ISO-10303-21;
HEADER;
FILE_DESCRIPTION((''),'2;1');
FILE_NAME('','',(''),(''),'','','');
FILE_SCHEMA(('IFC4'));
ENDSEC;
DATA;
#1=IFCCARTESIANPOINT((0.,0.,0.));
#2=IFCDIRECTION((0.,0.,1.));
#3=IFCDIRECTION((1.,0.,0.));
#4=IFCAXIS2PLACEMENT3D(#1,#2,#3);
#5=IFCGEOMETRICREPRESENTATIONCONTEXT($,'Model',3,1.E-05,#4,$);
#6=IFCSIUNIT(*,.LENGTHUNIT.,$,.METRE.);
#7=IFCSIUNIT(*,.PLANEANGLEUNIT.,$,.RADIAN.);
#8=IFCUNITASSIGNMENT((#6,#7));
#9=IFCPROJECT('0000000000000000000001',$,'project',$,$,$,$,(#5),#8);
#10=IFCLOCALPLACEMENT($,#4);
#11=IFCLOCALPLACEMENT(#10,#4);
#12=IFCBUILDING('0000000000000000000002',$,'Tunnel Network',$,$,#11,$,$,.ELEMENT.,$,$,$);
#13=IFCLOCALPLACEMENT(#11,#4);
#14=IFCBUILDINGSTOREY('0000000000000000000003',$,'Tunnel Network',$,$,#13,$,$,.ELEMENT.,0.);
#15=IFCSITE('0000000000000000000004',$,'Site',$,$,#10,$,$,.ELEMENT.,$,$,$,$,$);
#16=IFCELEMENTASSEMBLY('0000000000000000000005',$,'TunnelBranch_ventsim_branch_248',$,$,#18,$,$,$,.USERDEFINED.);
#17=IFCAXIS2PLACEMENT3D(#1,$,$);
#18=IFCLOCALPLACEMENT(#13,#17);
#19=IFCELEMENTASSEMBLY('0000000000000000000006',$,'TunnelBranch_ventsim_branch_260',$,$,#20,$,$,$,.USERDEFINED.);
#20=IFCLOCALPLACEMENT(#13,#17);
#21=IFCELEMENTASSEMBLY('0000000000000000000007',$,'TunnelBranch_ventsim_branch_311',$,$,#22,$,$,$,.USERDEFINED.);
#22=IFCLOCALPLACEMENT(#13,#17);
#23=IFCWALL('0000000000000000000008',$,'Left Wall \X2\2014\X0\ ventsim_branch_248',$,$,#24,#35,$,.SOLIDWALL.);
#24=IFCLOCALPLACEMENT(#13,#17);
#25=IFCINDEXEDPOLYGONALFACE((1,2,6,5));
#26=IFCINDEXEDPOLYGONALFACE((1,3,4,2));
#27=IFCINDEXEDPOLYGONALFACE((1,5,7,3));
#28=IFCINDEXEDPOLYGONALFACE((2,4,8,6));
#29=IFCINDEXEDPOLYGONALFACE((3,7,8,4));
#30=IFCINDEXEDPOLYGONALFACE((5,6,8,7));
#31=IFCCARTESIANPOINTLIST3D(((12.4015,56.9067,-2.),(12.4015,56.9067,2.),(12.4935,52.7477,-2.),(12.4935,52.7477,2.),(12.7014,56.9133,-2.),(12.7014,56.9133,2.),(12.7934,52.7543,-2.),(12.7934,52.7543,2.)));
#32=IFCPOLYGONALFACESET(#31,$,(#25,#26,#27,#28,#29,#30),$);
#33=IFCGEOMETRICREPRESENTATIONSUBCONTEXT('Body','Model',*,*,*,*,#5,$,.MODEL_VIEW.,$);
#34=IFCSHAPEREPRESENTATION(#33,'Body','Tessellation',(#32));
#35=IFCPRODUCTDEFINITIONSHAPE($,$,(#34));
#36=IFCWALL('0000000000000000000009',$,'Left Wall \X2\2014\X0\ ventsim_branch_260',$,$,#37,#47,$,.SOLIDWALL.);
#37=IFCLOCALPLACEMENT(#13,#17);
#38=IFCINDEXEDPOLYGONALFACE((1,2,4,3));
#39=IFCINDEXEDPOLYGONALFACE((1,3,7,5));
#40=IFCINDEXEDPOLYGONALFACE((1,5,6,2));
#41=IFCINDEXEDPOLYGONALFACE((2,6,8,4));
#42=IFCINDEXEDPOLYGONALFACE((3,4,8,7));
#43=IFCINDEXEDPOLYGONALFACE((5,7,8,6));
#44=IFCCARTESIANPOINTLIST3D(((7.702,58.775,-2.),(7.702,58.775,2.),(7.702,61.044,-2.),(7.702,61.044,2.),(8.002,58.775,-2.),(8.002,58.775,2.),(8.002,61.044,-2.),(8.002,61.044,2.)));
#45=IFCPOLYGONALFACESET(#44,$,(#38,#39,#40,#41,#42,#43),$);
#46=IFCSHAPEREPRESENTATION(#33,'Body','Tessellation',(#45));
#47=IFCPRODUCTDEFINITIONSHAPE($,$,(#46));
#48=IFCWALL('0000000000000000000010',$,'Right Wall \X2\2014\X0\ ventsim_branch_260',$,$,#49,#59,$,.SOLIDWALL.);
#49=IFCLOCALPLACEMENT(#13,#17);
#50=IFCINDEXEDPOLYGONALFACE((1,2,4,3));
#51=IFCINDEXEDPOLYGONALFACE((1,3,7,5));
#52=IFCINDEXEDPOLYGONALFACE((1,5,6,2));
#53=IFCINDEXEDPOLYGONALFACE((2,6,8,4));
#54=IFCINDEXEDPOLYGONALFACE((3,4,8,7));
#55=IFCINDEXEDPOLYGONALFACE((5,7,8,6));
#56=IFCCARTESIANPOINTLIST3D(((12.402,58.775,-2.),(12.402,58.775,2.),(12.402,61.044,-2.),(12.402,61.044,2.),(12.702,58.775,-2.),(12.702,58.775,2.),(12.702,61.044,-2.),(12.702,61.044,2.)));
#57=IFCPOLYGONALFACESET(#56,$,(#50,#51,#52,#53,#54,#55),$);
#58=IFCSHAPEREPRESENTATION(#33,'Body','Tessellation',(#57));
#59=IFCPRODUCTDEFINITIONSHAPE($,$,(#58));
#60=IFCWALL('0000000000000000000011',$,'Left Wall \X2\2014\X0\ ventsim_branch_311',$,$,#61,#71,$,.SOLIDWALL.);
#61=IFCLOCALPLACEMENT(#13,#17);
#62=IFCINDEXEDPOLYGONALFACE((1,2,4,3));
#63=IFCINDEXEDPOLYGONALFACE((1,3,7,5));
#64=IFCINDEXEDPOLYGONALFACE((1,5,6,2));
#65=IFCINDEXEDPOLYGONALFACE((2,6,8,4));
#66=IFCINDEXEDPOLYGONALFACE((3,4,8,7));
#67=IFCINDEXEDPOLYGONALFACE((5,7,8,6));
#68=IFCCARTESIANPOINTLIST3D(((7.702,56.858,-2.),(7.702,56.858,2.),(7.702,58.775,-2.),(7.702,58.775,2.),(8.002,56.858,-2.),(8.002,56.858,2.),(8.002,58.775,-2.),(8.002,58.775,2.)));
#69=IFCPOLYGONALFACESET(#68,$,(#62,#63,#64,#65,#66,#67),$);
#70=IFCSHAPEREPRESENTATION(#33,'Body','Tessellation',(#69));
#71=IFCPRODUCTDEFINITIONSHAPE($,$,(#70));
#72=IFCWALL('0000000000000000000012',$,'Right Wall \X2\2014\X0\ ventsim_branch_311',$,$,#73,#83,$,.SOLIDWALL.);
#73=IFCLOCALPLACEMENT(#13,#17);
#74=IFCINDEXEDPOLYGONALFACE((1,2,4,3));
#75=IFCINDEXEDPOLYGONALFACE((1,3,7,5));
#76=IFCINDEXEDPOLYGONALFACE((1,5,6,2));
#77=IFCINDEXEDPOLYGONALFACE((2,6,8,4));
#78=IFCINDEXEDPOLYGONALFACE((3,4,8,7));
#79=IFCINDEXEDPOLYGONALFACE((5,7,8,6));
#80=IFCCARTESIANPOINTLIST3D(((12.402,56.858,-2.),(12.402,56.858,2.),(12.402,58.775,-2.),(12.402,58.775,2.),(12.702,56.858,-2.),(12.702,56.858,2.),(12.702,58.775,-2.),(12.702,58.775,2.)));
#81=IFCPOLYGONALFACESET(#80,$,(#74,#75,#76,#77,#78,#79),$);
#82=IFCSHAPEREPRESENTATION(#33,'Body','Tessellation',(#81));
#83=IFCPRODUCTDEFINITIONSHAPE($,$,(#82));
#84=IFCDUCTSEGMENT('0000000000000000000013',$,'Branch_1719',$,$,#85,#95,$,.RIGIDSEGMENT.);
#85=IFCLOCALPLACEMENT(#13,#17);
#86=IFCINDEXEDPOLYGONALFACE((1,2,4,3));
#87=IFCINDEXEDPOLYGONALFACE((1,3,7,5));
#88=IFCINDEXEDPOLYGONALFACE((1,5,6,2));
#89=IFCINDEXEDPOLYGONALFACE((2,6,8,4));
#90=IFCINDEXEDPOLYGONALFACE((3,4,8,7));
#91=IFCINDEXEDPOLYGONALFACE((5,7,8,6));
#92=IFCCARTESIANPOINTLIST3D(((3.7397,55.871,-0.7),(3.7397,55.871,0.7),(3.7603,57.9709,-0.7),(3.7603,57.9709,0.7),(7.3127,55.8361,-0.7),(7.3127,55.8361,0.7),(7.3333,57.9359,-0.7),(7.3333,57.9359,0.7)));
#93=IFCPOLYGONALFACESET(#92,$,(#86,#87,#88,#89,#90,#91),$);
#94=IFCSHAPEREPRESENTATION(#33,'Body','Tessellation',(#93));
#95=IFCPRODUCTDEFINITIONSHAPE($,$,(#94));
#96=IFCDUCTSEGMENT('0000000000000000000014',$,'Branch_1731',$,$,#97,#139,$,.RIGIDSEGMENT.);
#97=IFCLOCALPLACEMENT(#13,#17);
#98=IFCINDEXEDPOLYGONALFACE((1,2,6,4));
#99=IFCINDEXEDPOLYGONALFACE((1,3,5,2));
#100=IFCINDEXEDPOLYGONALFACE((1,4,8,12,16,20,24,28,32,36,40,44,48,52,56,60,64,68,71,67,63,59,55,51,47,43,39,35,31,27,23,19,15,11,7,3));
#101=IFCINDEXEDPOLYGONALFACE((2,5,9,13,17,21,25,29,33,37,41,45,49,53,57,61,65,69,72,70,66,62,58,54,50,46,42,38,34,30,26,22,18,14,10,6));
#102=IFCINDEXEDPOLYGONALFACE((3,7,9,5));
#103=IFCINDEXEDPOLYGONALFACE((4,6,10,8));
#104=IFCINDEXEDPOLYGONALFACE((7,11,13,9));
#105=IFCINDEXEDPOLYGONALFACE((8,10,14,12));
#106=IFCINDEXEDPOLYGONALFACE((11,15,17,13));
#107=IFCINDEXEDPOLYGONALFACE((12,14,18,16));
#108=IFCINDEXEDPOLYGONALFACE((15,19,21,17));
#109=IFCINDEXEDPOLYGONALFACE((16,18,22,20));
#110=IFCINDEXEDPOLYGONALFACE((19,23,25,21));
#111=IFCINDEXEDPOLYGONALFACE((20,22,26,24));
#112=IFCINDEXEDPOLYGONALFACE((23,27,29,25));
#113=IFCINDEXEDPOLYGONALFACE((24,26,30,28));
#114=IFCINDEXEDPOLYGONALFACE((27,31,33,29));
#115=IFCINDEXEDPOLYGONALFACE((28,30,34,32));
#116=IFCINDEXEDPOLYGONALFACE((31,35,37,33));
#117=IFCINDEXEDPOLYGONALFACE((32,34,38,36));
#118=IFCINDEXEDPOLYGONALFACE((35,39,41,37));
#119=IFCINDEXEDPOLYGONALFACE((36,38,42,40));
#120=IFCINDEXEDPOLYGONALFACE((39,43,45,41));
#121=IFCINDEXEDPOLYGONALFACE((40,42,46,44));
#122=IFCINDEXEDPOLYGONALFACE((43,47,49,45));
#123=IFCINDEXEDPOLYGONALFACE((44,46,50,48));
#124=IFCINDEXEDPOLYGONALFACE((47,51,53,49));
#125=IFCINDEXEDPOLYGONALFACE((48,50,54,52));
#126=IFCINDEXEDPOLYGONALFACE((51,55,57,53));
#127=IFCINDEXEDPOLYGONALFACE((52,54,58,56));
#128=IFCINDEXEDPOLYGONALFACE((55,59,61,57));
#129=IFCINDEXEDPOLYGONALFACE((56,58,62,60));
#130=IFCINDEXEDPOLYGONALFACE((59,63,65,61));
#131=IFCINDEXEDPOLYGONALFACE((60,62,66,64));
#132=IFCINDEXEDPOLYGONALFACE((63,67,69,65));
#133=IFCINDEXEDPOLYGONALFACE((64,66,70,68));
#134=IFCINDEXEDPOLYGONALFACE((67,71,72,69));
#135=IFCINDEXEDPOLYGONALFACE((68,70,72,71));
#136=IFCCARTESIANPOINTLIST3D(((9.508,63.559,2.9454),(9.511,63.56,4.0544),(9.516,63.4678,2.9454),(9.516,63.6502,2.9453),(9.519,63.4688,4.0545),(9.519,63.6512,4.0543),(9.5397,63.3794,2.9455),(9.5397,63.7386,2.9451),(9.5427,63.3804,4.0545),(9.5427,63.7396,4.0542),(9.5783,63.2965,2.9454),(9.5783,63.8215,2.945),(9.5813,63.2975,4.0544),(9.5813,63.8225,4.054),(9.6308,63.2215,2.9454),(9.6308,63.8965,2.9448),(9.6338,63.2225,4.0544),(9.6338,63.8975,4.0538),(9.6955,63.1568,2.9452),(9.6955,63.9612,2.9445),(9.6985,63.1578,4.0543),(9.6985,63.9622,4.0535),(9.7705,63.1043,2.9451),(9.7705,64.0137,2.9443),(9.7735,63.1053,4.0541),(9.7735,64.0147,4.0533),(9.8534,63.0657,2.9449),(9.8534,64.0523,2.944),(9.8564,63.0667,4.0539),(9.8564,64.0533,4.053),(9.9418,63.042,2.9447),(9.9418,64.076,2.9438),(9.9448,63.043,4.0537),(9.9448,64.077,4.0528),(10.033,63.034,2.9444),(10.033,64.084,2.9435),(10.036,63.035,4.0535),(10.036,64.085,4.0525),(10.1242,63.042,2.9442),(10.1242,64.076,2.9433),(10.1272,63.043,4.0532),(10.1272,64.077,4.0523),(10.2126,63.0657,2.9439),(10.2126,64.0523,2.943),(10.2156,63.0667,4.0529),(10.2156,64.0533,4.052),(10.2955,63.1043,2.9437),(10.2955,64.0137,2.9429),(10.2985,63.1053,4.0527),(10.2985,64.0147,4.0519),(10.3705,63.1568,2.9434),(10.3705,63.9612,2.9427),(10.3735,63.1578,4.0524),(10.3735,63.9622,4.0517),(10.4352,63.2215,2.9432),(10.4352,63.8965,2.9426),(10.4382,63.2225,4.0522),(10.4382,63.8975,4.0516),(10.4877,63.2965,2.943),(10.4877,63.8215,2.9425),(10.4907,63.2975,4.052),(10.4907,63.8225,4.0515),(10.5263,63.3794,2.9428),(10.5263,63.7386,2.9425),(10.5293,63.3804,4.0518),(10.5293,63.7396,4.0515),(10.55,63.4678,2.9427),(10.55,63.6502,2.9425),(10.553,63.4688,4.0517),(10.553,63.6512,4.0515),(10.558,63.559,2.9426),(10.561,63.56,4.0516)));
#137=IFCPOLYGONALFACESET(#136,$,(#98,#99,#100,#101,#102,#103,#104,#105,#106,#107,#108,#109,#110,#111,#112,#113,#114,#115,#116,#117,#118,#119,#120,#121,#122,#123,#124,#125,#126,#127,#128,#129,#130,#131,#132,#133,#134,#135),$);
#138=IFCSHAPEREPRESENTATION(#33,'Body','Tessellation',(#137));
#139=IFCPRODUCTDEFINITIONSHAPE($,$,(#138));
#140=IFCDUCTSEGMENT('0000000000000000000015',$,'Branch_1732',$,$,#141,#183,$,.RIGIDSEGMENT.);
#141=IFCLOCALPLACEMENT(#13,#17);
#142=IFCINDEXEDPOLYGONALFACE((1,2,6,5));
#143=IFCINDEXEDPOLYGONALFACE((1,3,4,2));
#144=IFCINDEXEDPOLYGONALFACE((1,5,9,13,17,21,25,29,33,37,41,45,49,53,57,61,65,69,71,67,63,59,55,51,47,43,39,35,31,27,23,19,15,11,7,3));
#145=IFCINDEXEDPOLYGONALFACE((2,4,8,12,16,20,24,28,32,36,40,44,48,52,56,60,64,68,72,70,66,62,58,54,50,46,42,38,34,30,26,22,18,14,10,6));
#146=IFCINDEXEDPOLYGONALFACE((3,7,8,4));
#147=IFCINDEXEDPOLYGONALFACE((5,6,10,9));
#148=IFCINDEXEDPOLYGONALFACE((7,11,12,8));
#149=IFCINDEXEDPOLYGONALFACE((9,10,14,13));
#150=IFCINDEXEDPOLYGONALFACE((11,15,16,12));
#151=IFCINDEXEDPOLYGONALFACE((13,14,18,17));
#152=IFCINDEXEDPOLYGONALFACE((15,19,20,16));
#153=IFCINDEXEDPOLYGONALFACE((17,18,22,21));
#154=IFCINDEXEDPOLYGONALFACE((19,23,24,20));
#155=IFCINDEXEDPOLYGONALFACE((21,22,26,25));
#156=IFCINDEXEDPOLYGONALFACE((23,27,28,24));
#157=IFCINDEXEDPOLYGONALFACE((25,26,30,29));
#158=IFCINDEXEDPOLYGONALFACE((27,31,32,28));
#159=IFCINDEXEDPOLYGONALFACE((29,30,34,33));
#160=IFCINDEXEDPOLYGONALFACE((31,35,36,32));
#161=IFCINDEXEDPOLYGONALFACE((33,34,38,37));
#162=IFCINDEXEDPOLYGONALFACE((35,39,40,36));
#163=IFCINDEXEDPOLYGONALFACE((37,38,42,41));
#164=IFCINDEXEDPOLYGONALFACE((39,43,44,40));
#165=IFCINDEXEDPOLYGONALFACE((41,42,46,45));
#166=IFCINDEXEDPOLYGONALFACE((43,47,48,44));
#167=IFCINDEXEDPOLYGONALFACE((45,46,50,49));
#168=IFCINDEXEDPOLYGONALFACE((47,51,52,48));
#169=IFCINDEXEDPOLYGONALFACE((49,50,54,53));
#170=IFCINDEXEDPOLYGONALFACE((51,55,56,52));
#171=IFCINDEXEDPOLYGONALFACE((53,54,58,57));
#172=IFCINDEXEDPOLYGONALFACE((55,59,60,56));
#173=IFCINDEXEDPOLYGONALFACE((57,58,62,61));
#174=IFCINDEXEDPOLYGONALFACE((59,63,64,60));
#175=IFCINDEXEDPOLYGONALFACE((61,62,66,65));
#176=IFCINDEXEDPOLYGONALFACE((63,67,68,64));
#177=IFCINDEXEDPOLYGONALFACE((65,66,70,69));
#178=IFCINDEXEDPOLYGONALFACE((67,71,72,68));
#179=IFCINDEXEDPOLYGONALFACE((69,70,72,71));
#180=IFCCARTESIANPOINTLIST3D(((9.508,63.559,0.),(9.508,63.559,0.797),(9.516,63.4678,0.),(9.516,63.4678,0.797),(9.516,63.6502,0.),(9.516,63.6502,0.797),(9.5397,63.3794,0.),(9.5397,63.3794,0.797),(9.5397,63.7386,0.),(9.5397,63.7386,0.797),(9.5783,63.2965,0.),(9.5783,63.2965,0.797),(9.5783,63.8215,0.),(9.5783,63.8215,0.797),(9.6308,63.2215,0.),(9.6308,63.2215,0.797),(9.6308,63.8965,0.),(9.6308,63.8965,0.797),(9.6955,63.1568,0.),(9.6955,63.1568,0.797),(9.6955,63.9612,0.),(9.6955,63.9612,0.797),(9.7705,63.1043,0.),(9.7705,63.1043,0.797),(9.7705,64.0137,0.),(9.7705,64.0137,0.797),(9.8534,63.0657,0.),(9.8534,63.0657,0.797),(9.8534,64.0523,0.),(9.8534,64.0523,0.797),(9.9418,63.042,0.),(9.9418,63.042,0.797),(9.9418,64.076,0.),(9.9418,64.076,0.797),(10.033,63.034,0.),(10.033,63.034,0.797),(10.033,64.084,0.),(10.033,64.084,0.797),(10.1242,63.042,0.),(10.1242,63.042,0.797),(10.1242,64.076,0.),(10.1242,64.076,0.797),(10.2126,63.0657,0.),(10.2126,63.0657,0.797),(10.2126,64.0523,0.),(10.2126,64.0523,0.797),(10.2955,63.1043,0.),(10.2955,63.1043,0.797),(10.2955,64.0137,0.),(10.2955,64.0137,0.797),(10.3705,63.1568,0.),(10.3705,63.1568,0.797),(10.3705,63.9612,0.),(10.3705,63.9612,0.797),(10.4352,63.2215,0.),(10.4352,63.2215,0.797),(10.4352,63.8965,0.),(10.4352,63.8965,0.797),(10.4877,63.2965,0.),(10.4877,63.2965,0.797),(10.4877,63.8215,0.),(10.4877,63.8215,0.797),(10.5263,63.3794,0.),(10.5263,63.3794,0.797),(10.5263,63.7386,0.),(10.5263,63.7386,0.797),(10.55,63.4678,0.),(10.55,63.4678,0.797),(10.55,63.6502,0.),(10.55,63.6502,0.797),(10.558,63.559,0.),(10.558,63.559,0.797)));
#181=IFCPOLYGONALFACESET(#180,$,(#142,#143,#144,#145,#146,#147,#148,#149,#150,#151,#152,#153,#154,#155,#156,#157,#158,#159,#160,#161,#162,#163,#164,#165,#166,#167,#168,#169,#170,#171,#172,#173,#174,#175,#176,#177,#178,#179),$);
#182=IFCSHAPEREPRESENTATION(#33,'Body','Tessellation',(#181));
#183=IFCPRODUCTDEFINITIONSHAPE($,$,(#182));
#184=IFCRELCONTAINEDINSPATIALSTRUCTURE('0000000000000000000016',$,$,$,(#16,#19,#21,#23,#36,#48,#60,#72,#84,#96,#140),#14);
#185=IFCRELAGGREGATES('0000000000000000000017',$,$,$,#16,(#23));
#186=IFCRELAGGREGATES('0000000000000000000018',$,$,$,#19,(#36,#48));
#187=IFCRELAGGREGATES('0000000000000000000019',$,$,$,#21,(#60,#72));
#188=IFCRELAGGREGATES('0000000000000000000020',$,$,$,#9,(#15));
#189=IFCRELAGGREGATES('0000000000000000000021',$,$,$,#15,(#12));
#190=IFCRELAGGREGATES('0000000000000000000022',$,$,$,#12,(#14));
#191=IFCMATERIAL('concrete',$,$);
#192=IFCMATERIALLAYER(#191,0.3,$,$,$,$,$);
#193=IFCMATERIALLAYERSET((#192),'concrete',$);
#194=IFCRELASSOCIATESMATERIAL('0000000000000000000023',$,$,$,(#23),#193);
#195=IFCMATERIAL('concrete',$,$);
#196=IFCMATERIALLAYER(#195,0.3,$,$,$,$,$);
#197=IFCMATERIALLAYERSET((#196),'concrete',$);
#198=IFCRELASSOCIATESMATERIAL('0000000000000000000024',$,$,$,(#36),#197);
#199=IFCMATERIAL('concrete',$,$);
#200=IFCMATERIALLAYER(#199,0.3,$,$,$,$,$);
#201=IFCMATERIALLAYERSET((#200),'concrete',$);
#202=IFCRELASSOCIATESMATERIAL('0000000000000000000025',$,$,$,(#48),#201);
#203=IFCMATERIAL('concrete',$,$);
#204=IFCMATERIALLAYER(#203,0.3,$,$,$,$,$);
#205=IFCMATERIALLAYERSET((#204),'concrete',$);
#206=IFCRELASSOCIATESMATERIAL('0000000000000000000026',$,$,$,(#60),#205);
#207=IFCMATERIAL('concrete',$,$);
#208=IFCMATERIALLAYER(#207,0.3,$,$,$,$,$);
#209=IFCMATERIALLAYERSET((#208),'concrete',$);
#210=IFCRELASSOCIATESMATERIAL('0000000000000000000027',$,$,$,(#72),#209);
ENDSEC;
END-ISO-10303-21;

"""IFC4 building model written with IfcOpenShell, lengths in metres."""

from ifc_helpers import new_model, si_unit, frame, origin_with_axes, origin_2d_with_axis, place, context, subcontext, project, spatial, rectangle, circle, extrude, material, layer, layer_set, layer_usage, element, aggregate, save


model = new_model("IFC4")

# Units and contexts
model_context = context("Model", 3, precision=1e-05, world=origin_with_axes())
body_context = subcontext(model_context, "Body", "Model", "MODEL_VIEW")
ifc_project = project(units=[si_unit("LENGTHUNIT", "METRE"), si_unit("PLANEANGLEUNIT", "RADIAN")], contexts=[model_context])

# Site, building, storey
site_placement = place(None, origin_with_axes())
site = spatial("IfcSite", under=ifc_project, at=site_placement, Name="Site", CompositionType="ELEMENT")
building_placement = place(site_placement, origin_with_axes())
building = spatial("IfcBuilding", under=site, at=building_placement, Name="Tunnel Network", CompositionType="ELEMENT")
storey_placement = place(building_placement, origin_with_axes())
storey = spatial("IfcBuildingStorey", under=building, at=storey_placement, Name="Tunnel Network", CompositionType="ELEMENT", Elevation=0.0)

# Element assemblies
assembly_1_placement = place(storey_placement, frame((12.5514, 56.91, 0.0), z_axis=(0.022115, -0.999755, 0.0), x_axis=(-0.999755, -0.022115, 0.0)))
assembly_1 = element("IfcElementAssembly", 1, at=assembly_1_placement, inside=storey, Name="TunnelBranch_ventsim_branch_248", PredefinedType="USERDEFINED")
assembly_2_placement = place(storey_placement, frame((7.852, 58.775, 0.0), z_axis=(0.0, 1.0, 0.0), x_axis=(1.0, 0.0, 0.0)))
assembly_2 = element("IfcElementAssembly", 2, at=assembly_2_placement, inside=storey, Name="TunnelBranch_ventsim_branch_260", PredefinedType="USERDEFINED")
assembly_3_placement = place(storey_placement, frame((7.852, 56.858, 0.0), z_axis=(0.0, 1.0, 0.0), x_axis=(1.0, 0.0, 0.0)))
assembly_3 = element("IfcElementAssembly", 3, at=assembly_3_placement, inside=storey, Name="TunnelBranch_ventsim_branch_311", PredefinedType="USERDEFINED")

# Walls
ifc_material_1 = material(Name="concrete")
ifc_layer_1 = layer(ifc_material_1, 0.3)
ifc_layer_set_1 = layer_set([ifc_layer_1], Name="concrete")
ifc_layer_usage_1 = layer_usage(ifc_layer_set_1, "AXIS2", "POSITIVE", 0.0)
wall_1_placement = place(storey_placement, frame((12.5514, 56.91, 0.0), z_axis=(0.022115, -0.999755, 0.0), x_axis=(-0.999755, -0.022115, 0.0)))
wall_1 = element("IfcWall", 4, at=wall_1_placement, inside=storey, material=ifc_layer_usage_1, Name="Left Wall — ventsim_branch_248", PredefinedType="SOLIDWALL", context=body_context, shape_type="SweptSolid", body=[
    extrude(rectangle(XDim=0.3, YDim=4.0, at=origin_2d_with_axis()), origin_with_axes(), (0.0, 0.0, 1.0), 4.16),
])
aggregate(assembly_1, [wall_1])
ifc_material_2 = material(Name="concrete")
ifc_layer_2 = layer(ifc_material_2, 0.3)
ifc_layer_set_2 = layer_set([ifc_layer_2], Name="concrete")
ifc_layer_usage_2 = layer_usage(ifc_layer_set_2, "AXIS2", "POSITIVE", 0.0)
wall_2_placement = place(storey_placement, frame((7.852, 58.775, 0.0), z_axis=(0.0, 1.0, 0.0), x_axis=(1.0, 0.0, 0.0)))
wall_2 = element("IfcWall", 5, at=wall_2_placement, inside=storey, material=ifc_layer_usage_2, Name="Left Wall — ventsim_branch_260", PredefinedType="SOLIDWALL", context=body_context, shape_type="SweptSolid", body=[
    extrude(rectangle(XDim=0.3, YDim=4.0, at=origin_2d_with_axis()), origin_with_axes(), (0.0, 0.0, 1.0), 2.269),
])
ifc_material_3 = material(Name="concrete")
ifc_layer_3 = layer(ifc_material_3, 0.3)
ifc_layer_set_3 = layer_set([ifc_layer_3], Name="concrete")
ifc_layer_usage_3 = layer_usage(ifc_layer_set_3, "AXIS2", "POSITIVE", 0.0)
wall_3_placement = place(storey_placement, frame((12.552, 58.775, 0.0), z_axis=(0.0, 1.0, 0.0), x_axis=(1.0, 0.0, 0.0)))
wall_3 = element("IfcWall", 6, at=wall_3_placement, inside=storey, material=ifc_layer_usage_3, Name="Right Wall — ventsim_branch_260", PredefinedType="SOLIDWALL", context=body_context, shape_type="SweptSolid", body=[
    extrude(rectangle(XDim=0.3, YDim=4.0, at=origin_2d_with_axis()), origin_with_axes(), (0.0, 0.0, 1.0), 2.269),
])
aggregate(assembly_2, [wall_2, wall_3])
ifc_material_4 = material(Name="concrete")
ifc_layer_4 = layer(ifc_material_4, 0.3)
ifc_layer_set_4 = layer_set([ifc_layer_4], Name="concrete")
ifc_layer_usage_4 = layer_usage(ifc_layer_set_4, "AXIS2", "POSITIVE", 0.0)
wall_4_placement = place(storey_placement, frame((7.852, 56.858, 0.0), z_axis=(0.0, 1.0, 0.0), x_axis=(1.0, 0.0, 0.0)))
wall_4 = element("IfcWall", 7, at=wall_4_placement, inside=storey, material=ifc_layer_usage_4, Name="Left Wall — ventsim_branch_311", PredefinedType="SOLIDWALL", context=body_context, shape_type="SweptSolid", body=[
    extrude(rectangle(XDim=0.3, YDim=4.0, at=origin_2d_with_axis()), origin_with_axes(), (0.0, 0.0, 1.0), 1.917),
])
ifc_material_5 = material(Name="concrete")
ifc_layer_5 = layer(ifc_material_5, 0.3)
ifc_layer_set_5 = layer_set([ifc_layer_5], Name="concrete")
ifc_layer_usage_5 = layer_usage(ifc_layer_set_5, "AXIS2", "POSITIVE", 0.0)
wall_5_placement = place(storey_placement, frame((12.552, 56.858, 0.0), z_axis=(0.0, 1.0, 0.0), x_axis=(1.0, 0.0, 0.0)))
wall_5 = element("IfcWall", 8, at=wall_5_placement, inside=storey, material=ifc_layer_usage_5, Name="Right Wall — ventsim_branch_311", PredefinedType="SOLIDWALL", context=body_context, shape_type="SweptSolid", body=[
    extrude(rectangle(XDim=0.3, YDim=4.0, at=origin_2d_with_axis()), origin_with_axes(), (0.0, 0.0, 1.0), 1.917),
])
aggregate(assembly_3, [wall_4, wall_5])

# Duct segments
duct_segment_1_placement = place(storey_placement, frame((3.75, 56.921, 0.0), z_axis=(0.999952, -0.009795, 0.0), x_axis=(0.0, 0.0, 1.0)))
element("IfcDuctSegment", 9, at=duct_segment_1_placement, inside=storey, Name="Branch_1719", PredefinedType="RIGIDSEGMENT", context=body_context, shape_type="SweptSolid", body=[
    extrude(rectangle(XDim=1.4, YDim=2.1, at=origin_2d_with_axis()), origin_with_axes(), (0.0, 0.0, 1.0), 3.5732),
])
duct_segment_2_placement = place(storey_placement, frame((10.033, 63.559, 2.944), z_axis=(0.002704, 0.000901, 0.999996), x_axis=(0.999996, -0.000002, -0.002704)))
element("IfcDuctSegment", 10, at=duct_segment_2_placement, inside=storey, Name="Branch_1731", PredefinedType="RIGIDSEGMENT", context=body_context, shape_type="SweptSolid", body=[
    extrude(circle(Radius=0.525, at=origin_2d_with_axis()), origin_with_axes(), (0.0, 0.0, 1.0), 1.109),
])
duct_segment_3_placement = place(storey_placement, frame((10.033, 63.559, 0.0), z_axis=(0.0, 0.0, 1.0), x_axis=(1.0, 0.0, 0.0)))
element("IfcDuctSegment", 11, at=duct_segment_3_placement, inside=storey, Name="Branch_1732", PredefinedType="RIGIDSEGMENT", context=body_context, shape_type="SweptSolid", body=[
    extrude(circle(Radius=0.525, at=origin_2d_with_axis()), origin_with_axes(), (0.0, 0.0, 1.0), 0.797),
])

save(model, "model.ifc")
